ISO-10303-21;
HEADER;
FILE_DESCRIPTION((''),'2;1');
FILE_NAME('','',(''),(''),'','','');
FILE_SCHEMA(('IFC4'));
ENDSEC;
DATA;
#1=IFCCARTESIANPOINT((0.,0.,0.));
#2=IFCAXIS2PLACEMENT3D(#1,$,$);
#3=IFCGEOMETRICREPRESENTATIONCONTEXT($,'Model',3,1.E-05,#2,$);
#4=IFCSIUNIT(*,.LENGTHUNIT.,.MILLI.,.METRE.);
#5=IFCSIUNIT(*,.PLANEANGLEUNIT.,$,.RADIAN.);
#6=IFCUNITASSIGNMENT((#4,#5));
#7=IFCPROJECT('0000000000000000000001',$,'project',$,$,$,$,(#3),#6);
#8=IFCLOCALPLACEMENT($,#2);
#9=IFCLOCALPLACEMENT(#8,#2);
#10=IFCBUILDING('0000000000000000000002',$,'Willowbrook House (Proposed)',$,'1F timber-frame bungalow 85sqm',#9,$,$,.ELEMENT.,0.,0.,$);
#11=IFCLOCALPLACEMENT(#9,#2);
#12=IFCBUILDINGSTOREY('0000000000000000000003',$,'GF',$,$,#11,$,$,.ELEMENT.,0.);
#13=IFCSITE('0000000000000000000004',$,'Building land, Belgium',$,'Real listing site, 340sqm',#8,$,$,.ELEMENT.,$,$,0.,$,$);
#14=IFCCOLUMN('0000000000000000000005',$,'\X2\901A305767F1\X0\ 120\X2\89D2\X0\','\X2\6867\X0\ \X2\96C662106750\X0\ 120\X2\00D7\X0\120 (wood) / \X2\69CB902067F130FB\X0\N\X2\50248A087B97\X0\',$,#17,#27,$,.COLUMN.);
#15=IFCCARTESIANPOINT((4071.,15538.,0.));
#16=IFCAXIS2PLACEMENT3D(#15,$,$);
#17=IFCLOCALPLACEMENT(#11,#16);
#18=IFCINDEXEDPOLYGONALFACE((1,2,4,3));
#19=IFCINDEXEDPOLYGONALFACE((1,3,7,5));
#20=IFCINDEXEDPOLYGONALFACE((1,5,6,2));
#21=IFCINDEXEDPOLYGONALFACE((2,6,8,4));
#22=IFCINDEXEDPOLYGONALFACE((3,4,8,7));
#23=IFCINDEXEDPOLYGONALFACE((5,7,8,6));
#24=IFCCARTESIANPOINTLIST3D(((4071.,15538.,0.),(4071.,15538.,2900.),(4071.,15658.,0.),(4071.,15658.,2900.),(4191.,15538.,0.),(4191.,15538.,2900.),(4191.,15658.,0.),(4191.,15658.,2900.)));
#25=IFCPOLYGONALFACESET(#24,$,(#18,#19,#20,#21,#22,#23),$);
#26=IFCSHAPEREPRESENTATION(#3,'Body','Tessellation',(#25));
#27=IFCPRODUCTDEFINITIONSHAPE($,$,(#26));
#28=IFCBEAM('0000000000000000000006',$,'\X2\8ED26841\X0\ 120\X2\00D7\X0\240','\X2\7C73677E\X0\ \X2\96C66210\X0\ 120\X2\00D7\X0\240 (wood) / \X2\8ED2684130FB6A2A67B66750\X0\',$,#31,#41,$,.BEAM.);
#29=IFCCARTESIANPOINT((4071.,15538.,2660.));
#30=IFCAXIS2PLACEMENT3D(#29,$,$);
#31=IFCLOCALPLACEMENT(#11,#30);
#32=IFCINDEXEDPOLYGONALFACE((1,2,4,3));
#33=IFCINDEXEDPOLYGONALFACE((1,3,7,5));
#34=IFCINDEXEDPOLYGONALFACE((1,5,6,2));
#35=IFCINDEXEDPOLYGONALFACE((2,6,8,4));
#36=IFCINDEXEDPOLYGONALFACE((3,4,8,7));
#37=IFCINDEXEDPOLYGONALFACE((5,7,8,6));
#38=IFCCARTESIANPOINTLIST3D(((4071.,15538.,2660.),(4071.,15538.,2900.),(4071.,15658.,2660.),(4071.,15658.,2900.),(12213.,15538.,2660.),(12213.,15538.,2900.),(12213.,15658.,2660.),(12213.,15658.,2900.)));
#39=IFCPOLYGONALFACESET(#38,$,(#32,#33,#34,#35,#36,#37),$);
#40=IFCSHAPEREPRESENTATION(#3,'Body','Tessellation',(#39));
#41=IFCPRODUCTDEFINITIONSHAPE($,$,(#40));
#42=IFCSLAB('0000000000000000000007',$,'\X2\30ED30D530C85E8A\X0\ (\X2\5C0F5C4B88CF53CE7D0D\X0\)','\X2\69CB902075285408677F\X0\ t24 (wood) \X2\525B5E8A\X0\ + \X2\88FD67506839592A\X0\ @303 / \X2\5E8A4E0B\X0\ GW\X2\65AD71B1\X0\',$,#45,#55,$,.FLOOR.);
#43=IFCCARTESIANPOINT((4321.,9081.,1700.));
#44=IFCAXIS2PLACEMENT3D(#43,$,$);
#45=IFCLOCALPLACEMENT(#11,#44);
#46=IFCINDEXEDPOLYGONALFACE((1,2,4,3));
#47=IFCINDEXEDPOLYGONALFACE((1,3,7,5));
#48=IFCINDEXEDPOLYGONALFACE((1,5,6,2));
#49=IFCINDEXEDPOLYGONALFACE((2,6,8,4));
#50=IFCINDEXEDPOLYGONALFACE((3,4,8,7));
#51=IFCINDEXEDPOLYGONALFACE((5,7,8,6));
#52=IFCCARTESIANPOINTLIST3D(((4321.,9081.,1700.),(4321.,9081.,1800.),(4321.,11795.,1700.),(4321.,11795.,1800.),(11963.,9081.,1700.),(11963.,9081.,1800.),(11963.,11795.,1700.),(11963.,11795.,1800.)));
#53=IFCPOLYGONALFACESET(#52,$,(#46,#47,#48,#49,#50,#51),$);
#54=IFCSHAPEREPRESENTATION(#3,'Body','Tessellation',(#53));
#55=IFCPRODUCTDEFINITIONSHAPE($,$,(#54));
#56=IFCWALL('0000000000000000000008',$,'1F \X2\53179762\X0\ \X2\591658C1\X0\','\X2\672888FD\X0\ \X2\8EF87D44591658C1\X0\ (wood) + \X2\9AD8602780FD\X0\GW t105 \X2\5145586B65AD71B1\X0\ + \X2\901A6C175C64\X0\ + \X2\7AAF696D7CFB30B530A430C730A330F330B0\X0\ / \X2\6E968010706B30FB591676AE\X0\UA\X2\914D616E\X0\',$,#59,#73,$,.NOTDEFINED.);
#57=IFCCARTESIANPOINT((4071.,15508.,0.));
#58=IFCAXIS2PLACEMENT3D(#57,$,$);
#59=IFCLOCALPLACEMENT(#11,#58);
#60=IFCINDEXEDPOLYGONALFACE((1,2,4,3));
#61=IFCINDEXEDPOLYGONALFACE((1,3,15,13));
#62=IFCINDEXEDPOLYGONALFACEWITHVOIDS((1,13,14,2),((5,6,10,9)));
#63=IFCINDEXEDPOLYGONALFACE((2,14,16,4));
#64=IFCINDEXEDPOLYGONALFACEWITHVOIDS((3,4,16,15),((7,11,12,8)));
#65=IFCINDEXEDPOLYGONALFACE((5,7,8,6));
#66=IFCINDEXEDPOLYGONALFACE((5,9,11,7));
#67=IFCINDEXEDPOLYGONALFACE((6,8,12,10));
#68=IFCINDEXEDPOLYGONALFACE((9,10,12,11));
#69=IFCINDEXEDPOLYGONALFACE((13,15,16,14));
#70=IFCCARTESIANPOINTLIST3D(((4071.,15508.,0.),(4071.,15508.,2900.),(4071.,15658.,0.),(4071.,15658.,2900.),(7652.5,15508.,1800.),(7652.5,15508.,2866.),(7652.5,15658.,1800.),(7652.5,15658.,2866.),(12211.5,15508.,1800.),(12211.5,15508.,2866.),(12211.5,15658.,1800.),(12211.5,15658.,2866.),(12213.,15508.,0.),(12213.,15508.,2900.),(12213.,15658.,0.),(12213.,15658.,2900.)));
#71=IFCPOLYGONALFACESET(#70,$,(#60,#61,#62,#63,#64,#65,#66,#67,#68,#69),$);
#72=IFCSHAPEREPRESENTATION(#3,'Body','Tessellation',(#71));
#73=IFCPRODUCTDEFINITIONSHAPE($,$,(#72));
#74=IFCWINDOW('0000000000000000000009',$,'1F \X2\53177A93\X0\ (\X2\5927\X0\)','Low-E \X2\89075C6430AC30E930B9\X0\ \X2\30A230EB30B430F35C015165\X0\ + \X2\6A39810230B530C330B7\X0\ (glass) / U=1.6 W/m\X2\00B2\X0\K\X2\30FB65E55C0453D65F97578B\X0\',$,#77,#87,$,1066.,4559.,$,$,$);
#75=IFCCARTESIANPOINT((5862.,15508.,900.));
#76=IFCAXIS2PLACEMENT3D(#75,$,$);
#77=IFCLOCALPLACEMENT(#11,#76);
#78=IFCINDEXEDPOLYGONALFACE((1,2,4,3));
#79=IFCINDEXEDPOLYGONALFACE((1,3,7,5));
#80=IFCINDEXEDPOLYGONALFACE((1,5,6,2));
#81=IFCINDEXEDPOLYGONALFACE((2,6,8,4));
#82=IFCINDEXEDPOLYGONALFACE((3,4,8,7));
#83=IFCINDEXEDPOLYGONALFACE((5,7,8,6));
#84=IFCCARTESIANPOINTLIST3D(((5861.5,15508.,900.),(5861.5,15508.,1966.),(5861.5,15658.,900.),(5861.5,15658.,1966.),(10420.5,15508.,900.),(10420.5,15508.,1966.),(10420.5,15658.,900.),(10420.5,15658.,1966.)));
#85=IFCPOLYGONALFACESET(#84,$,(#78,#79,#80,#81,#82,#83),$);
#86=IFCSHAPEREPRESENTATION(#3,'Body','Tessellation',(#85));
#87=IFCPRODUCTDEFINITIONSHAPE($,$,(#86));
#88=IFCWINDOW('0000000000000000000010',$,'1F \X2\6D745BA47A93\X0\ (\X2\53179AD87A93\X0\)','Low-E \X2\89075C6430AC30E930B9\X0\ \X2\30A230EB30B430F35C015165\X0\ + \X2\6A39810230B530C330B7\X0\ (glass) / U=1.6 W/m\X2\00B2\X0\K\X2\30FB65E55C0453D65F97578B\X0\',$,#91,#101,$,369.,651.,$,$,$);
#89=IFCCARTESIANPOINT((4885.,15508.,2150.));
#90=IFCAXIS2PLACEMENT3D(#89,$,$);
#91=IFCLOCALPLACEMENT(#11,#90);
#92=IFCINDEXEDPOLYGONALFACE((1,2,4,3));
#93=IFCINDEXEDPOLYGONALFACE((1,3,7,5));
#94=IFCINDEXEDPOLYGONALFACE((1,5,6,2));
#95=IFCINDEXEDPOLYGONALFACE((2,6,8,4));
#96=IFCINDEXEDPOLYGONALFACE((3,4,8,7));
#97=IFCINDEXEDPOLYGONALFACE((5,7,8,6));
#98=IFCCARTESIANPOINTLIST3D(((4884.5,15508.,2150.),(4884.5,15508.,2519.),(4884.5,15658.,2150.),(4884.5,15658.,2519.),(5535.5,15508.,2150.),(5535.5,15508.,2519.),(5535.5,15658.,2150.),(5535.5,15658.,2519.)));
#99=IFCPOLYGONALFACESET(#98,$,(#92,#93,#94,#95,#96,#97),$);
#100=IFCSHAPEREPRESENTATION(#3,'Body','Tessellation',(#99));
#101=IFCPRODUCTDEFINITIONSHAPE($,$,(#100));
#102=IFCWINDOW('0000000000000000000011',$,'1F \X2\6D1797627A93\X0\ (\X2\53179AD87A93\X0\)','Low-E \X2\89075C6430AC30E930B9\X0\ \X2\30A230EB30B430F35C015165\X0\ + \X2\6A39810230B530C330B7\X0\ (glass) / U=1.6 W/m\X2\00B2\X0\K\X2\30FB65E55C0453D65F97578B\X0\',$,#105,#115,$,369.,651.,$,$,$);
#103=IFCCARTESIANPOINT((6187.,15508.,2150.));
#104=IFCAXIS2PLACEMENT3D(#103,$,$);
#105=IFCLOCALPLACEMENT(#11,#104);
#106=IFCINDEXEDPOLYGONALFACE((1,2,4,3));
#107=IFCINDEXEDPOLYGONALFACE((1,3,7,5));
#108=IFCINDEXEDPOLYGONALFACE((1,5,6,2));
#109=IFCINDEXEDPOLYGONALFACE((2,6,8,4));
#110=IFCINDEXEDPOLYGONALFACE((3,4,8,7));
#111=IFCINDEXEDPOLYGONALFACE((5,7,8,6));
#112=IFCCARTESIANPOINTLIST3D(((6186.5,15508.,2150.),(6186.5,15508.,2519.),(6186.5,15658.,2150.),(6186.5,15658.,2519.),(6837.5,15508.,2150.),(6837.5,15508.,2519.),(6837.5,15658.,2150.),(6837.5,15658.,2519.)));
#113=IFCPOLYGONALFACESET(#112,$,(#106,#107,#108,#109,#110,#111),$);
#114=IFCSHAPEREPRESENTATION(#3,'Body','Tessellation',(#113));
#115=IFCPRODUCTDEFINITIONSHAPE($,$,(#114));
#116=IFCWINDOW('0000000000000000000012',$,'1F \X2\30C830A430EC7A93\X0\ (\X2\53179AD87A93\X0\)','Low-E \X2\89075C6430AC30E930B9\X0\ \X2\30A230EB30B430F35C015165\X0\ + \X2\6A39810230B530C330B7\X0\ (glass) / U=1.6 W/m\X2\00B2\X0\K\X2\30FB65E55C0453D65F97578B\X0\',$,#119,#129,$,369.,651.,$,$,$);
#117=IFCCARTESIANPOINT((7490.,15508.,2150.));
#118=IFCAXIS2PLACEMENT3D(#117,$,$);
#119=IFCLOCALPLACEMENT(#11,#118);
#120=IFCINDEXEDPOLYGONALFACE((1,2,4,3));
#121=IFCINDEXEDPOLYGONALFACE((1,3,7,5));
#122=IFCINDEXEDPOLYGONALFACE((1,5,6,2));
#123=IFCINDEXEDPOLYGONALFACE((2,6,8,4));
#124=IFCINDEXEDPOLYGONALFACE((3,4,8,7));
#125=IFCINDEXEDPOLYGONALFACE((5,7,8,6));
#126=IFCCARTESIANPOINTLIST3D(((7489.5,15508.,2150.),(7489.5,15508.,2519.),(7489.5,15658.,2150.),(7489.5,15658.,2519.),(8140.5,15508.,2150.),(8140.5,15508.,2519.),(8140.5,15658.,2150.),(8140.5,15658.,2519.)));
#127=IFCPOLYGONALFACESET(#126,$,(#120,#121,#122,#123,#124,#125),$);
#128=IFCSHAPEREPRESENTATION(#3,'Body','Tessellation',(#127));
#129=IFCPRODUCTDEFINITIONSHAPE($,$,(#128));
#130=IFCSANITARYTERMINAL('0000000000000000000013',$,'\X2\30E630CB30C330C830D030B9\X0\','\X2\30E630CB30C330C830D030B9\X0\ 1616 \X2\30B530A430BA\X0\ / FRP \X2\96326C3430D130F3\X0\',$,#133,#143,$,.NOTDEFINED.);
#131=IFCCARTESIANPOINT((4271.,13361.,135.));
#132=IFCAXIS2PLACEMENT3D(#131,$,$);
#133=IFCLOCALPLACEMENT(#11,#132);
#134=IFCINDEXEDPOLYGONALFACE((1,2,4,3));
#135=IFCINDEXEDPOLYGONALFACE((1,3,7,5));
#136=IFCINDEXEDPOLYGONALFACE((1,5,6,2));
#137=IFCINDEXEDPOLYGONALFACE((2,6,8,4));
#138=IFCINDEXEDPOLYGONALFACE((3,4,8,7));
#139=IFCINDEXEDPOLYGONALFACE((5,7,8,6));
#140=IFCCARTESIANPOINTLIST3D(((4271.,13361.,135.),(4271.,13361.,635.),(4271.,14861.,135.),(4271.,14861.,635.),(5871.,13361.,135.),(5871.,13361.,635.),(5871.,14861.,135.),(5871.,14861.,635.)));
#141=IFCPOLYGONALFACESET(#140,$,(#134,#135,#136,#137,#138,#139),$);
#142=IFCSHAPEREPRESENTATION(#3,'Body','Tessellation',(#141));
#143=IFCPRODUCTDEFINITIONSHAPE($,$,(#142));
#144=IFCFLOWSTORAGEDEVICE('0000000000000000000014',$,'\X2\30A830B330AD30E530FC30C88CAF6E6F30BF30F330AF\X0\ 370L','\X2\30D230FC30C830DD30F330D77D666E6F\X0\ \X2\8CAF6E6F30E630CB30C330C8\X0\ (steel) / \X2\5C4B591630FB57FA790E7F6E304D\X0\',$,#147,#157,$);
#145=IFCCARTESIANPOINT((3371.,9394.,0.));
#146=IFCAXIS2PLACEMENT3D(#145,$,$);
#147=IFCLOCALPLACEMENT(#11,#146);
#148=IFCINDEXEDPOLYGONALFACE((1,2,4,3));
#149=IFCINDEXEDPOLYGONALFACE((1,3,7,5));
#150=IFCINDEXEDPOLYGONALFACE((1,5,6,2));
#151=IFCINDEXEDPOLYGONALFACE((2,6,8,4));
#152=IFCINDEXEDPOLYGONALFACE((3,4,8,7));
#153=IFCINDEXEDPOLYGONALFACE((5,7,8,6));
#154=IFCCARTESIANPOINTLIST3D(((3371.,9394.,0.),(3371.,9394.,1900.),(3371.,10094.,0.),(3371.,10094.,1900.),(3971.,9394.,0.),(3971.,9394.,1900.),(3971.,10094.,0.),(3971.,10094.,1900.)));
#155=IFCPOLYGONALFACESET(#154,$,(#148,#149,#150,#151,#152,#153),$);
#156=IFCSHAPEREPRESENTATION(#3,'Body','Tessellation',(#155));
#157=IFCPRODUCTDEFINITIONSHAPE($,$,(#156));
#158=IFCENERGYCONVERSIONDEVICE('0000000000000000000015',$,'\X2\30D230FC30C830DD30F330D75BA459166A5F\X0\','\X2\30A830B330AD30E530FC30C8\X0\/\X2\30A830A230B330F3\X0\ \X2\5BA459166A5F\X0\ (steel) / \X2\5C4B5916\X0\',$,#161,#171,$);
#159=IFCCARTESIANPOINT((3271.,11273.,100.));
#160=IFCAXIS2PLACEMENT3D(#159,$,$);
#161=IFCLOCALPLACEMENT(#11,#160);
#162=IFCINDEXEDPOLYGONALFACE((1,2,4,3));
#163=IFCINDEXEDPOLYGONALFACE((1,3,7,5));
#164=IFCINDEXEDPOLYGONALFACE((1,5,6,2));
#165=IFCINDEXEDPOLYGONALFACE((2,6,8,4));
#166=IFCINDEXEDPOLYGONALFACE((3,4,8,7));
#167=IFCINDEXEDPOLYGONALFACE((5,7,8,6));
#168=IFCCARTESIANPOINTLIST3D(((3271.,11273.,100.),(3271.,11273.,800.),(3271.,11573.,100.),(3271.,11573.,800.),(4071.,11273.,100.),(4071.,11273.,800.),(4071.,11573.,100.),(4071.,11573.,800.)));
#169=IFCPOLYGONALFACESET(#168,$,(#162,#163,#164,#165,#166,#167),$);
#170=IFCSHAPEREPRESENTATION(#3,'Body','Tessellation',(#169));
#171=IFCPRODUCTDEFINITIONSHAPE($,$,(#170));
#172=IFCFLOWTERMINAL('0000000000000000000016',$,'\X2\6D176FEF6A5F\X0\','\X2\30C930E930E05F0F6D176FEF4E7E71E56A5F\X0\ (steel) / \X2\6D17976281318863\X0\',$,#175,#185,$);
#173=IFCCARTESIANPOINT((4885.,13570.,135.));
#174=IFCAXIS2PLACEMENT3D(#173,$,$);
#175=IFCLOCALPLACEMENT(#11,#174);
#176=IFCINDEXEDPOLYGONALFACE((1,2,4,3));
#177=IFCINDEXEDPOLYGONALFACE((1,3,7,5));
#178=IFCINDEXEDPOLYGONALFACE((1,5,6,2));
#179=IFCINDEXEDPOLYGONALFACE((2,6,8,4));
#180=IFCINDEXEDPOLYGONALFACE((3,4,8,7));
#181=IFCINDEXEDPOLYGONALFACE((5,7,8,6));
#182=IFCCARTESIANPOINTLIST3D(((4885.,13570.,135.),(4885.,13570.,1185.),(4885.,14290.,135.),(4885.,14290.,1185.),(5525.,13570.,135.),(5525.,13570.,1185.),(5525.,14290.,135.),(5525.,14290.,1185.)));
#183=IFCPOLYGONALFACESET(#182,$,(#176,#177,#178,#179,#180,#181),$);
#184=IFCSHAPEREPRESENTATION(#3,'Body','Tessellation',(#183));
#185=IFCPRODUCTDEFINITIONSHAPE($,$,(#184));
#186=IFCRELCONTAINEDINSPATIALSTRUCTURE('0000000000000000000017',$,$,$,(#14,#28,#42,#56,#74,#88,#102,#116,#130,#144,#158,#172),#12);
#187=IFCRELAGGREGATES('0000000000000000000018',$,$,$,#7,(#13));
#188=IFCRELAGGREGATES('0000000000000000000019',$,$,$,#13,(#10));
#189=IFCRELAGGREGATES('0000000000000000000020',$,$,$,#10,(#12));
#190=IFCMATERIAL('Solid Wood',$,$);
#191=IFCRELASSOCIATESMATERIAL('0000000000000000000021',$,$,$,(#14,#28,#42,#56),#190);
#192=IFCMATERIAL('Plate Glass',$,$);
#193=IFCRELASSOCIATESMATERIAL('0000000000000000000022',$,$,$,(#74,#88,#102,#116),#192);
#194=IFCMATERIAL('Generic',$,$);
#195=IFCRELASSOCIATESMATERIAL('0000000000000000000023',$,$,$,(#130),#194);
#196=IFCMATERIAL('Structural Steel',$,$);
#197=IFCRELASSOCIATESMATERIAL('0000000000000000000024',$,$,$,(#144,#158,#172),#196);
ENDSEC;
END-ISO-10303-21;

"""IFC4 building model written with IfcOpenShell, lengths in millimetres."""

from ifc_helpers import new_model, si_unit, frame, frame_2d, origin, place, context, project, spatial, rectangle, extrude, material, element, fill, save


model = new_model("IFC4")

# Units and contexts
model_context = context("Model", 3, precision=1e-05, world=origin())
ifc_project = project(units=[si_unit("LENGTHUNIT", "METRE", prefix="MILLI"), si_unit("PLANEANGLEUNIT", "RADIAN")], contexts=[model_context])

# Site, building, storey
site_placement = place(None, origin())
site = spatial("IfcSite", under=ifc_project, at=site_placement, Name="Building land, Belgium", ObjectType="Real listing site, 340sqm", CompositionType="ELEMENT", RefElevation=0.0)
building_placement = place(site_placement, origin())
building = spatial("IfcBuilding", under=site, at=building_placement, Name="Willowbrook House (Proposed)", ObjectType="1F timber-frame bungalow 85sqm", CompositionType="ELEMENT", ElevationOfRefHeight=0.0, ElevationOfTerrain=0.0)
storey_placement = place(building_placement, origin())
storey = spatial("IfcBuildingStorey", under=building, at=storey_placement, Name="GF", CompositionType="ELEMENT", Elevation=0.0)

# Column
ifc_material_1 = material(Name="Solid Wood")
column_1_placement = place(storey_placement, frame((4071.0, 15538.0, 0.0)))
element("IfcColumn", 1, at=column_1_placement, inside=storey, material=ifc_material_1, Name="通し柱 120角", Description="桧 集成材 120×120 (wood) / 構造柱・N値計算", PredefinedType="COLUMN", context=model_context, shape_type="SweptSolid", body=[
    extrude(rectangle(XDim=120.0, YDim=120.0, at=frame_2d((60.0, 60.0))), frame((4071.0, 15538.0, 0.0)), (0.0, 0.0, 1.0), 2900.0),
])

# Beam
beam_1_placement = place(storey_placement, frame((4071.0, 15538.0, 2660.0)))
element("IfcBeam", 2, at=beam_1_placement, inside=storey, material=ifc_material_1, Name="軒桁 120×240", Description="米松 集成 120×240 (wood) / 軒桁・横架材", PredefinedType="BEAM", context=model_context, shape_type="SweptSolid", body=[
    extrude(rectangle(XDim=8142.0, YDim=120.0, at=frame_2d((4071.0, 60.0))), frame((4071.0, 15538.0, 2660.0)), (0.0, 0.0, 1.0), 240.0),
])

# Slab
slab_placement = place(storey_placement, frame((4321.0, 9081.0, 1700.0)))
element("IfcSlab", 3, at=slab_placement, inside=storey, material=ifc_material_1, Name="ロフト床 (小屋裏収納)", Description="構造用合板 t24 (wood) 剛床 + 製材根太 @303 / 床下 GW断熱", PredefinedType="FLOOR", context=model_context, shape_type="SweptSolid", body=[
    extrude(rectangle(XDim=7642.0, YDim=2714.0, at=frame_2d((3821.0, 1357.0))), frame((4321.0, 9081.0, 1700.0)), (0.0, 0.0, 1.0), 100.0),
])

# Wall, openings, windows
wall_1_placement = place(storey_placement, frame((4071.0, 15508.0, 0.0)))
wall_1 = element("IfcWall", 4, at=wall_1_placement, inside=storey, material=ifc_material_1, Name="1F 北面 外壁", Description="木製 軸組外壁 (wood) + 高性能GW t105 充填断熱 + 通気層 + 窯業系サイディング / 準耐火・外皮UA配慮", PredefinedType="NOTDEFINED", context=model_context, shape_type="SweptSolid", body=[
    extrude(rectangle(XDim=8142.0, YDim=150.0, at=frame_2d((4071.0, 75.0))), frame((4071.0, 15508.0, 0.0)), (0.0, 0.0, 1.0), 2900.0),
])
opening_1_placement = place(storey_placement, frame((5862.0, 15508.0, 900.0)))
opening_1 = element("IfcOpeningElement", 5, at=opening_1_placement, cuts=wall_1, PredefinedType="NOTDEFINED", context=model_context, shape_type="SweptSolid", body=[
    extrude(rectangle(XDim=4559.0, YDim=150.0, at=frame_2d((2279.0, 75.0))), frame((5862.0, 15508.0, 900.0)), (0.0, 0.0, 1.0), 1066.0),
])
opening_2_placement = place(storey_placement, frame((4885.0, 15508.0, 2150.0)))
opening_2 = element("IfcOpeningElement", 6, at=opening_2_placement, cuts=wall_1, PredefinedType="NOTDEFINED", context=model_context, shape_type="SweptSolid", body=[
    extrude(rectangle(XDim=651.0, YDim=150.0, at=frame_2d((325.0, 75.0))), frame((4885.0, 15508.0, 2150.0)), (0.0, 0.0, 1.0), 369.0),
])
opening_3_placement = place(storey_placement, frame((6187.0, 15508.0, 2150.0)))
opening_3 = element("IfcOpeningElement", 7, at=opening_3_placement, cuts=wall_1, PredefinedType="NOTDEFINED", context=model_context, shape_type="SweptSolid", body=[
    extrude(rectangle(XDim=651.0, YDim=150.0, at=frame_2d((325.0, 75.0))), frame((6187.0, 15508.0, 2150.0)), (0.0, 0.0, 1.0), 369.0),
])
opening_4_placement = place(storey_placement, frame((7490.0, 15508.0, 2150.0)))
opening_4 = element("IfcOpeningElement", 8, at=opening_4_placement, cuts=wall_1, PredefinedType="NOTDEFINED", context=model_context, shape_type="SweptSolid", body=[
    extrude(rectangle(XDim=651.0, YDim=150.0, at=frame_2d((325.0, 75.0))), frame((7490.0, 15508.0, 2150.0)), (0.0, 0.0, 1.0), 369.0),
])
ifc_material_2 = material(Name="Plate Glass")
window_1_placement = place(storey_placement, frame((5862.0, 15508.0, 900.0)))
window_1 = element("IfcWindow", 9, at=window_1_placement, inside=storey, material=ifc_material_2, Name="1F 北窓 (大)", Description="Low-E 複層ガラス アルゴン封入 + 樹脂サッシ (glass) / U=1.6 W/m²K・日射取得型", OverallHeight=1066.0, OverallWidth=4559.0, context=model_context, shape_type="SweptSolid", body=[
    extrude(rectangle(XDim=4559.0, YDim=150.0, at=frame_2d((2279.0, 75.0))), frame((5862.0, 15508.0, 900.0)), (0.0, 0.0, 1.0), 1066.0),
])
fill(opening_1, window_1)
window_2_placement = place(storey_placement, frame((4885.0, 15508.0, 2150.0)))
window_2 = element("IfcWindow", 10, at=window_2_placement, inside=storey, material=ifc_material_2, Name="1F 浴室窓 (北高窓)", Description="Low-E 複層ガラス アルゴン封入 + 樹脂サッシ (glass) / U=1.6 W/m²K・日射取得型", OverallHeight=369.0, OverallWidth=651.0, context=model_context, shape_type="SweptSolid", body=[
    extrude(rectangle(XDim=651.0, YDim=150.0, at=frame_2d((325.0, 75.0))), frame((4885.0, 15508.0, 2150.0)), (0.0, 0.0, 1.0), 369.0),
])
fill(opening_2, window_2)
window_3_placement = place(storey_placement, frame((6187.0, 15508.0, 2150.0)))
window_3 = element("IfcWindow", 11, at=window_3_placement, inside=storey, material=ifc_material_2, Name="1F 洗面窓 (北高窓)", Description="Low-E 複層ガラス アルゴン封入 + 樹脂サッシ (glass) / U=1.6 W/m²K・日射取得型", OverallHeight=369.0, OverallWidth=651.0, context=model_context, shape_type="SweptSolid", body=[
    extrude(rectangle(XDim=651.0, YDim=150.0, at=frame_2d((325.0, 75.0))), frame((6187.0, 15508.0, 2150.0)), (0.0, 0.0, 1.0), 369.0),
])
fill(opening_3, window_3)
window_4_placement = place(storey_placement, frame((7490.0, 15508.0, 2150.0)))
window_4 = element("IfcWindow", 12, at=window_4_placement, inside=storey, material=ifc_material_2, Name="1F トイレ窓 (北高窓)", Description="Low-E 複層ガラス アルゴン封入 + 樹脂サッシ (glass) / U=1.6 W/m²K・日射取得型", OverallHeight=369.0, OverallWidth=651.0, context=model_context, shape_type="SweptSolid", body=[
    extrude(rectangle(XDim=651.0, YDim=150.0, at=frame_2d((325.0, 75.0))), frame((7490.0, 15508.0, 2150.0)), (0.0, 0.0, 1.0), 369.0),
])
fill(opening_4, window_4)

# Sanitary terminal
ifc_material_3 = material(Name="Generic")
sanitary_terminal_placement = place(storey_placement, frame((4271.0, 13361.0, 135.0)))
element("IfcSanitaryTerminal", 13, at=sanitary_terminal_placement, inside=storey, material=ifc_material_3, Name="ユニットバス", Description="ユニットバス 1616 サイズ / FRP 防水パン", PredefinedType="NOTDEFINED", context=model_context, shape_type="SweptSolid", body=[
    extrude(rectangle(XDim=1600.0, YDim=1500.0, at=frame_2d((800.0, 750.0))), frame((4271.0, 13361.0, 135.0)), (0.0, 0.0, 1.0), 500.0),
])

# Flow storage device
ifc_material_4 = material(Name="Structural Steel")
flow_storage_device_placement = place(storey_placement, frame((3371.0, 9394.0, 0.0)))
element("IfcFlowStorageDevice", 14, at=flow_storage_device_placement, inside=storey, material=ifc_material_4, Name="エコキュート貯湯タンク 370L", Description="ヒートポンプ給湯 貯湯ユニット (steel) / 屋外・基礎置き", context=model_context, shape_type="SweptSolid", body=[
    extrude(rectangle(XDim=600.0, YDim=700.0, at=frame_2d((300.0, 350.0))), frame((3371.0, 9394.0, 0.0)), (0.0, 0.0, 1.0), 1900.0),
])

# Energy conversion device
energy_conversion_device_placement = place(storey_placement, frame((3271.0, 11273.0, 100.0)))
element("IfcEnergyConversionDevice", 15, at=energy_conversion_device_placement, inside=storey, material=ifc_material_4, Name="ヒートポンプ室外機", Description="エコキュート/エアコン 室外機 (steel) / 屋外", context=model_context, shape_type="SweptSolid", body=[
    extrude(rectangle(XDim=800.0, YDim=300.0, at=frame_2d((400.0, 150.0))), frame((3271.0, 11273.0, 100.0)), (0.0, 0.0, 1.0), 700.0),
])

# Flow terminal
flow_terminal_placement = place(storey_placement, frame((4885.0, 13570.0, 135.0)))
element("IfcFlowTerminal", 16, at=flow_terminal_placement, inside=storey, material=ifc_material_4, Name="洗濯機", Description="ドラム式洗濯乾燥機 (steel) / 洗面脱衣", context=model_context, shape_type="SweptSolid", body=[
    extrude(rectangle(XDim=640.0, YDim=720.0, at=frame_2d((320.0, 360.0))), frame((4885.0, 13570.0, 135.0)), (0.0, 0.0, 1.0), 1050.0),
])

save(model, "model.ifc")
